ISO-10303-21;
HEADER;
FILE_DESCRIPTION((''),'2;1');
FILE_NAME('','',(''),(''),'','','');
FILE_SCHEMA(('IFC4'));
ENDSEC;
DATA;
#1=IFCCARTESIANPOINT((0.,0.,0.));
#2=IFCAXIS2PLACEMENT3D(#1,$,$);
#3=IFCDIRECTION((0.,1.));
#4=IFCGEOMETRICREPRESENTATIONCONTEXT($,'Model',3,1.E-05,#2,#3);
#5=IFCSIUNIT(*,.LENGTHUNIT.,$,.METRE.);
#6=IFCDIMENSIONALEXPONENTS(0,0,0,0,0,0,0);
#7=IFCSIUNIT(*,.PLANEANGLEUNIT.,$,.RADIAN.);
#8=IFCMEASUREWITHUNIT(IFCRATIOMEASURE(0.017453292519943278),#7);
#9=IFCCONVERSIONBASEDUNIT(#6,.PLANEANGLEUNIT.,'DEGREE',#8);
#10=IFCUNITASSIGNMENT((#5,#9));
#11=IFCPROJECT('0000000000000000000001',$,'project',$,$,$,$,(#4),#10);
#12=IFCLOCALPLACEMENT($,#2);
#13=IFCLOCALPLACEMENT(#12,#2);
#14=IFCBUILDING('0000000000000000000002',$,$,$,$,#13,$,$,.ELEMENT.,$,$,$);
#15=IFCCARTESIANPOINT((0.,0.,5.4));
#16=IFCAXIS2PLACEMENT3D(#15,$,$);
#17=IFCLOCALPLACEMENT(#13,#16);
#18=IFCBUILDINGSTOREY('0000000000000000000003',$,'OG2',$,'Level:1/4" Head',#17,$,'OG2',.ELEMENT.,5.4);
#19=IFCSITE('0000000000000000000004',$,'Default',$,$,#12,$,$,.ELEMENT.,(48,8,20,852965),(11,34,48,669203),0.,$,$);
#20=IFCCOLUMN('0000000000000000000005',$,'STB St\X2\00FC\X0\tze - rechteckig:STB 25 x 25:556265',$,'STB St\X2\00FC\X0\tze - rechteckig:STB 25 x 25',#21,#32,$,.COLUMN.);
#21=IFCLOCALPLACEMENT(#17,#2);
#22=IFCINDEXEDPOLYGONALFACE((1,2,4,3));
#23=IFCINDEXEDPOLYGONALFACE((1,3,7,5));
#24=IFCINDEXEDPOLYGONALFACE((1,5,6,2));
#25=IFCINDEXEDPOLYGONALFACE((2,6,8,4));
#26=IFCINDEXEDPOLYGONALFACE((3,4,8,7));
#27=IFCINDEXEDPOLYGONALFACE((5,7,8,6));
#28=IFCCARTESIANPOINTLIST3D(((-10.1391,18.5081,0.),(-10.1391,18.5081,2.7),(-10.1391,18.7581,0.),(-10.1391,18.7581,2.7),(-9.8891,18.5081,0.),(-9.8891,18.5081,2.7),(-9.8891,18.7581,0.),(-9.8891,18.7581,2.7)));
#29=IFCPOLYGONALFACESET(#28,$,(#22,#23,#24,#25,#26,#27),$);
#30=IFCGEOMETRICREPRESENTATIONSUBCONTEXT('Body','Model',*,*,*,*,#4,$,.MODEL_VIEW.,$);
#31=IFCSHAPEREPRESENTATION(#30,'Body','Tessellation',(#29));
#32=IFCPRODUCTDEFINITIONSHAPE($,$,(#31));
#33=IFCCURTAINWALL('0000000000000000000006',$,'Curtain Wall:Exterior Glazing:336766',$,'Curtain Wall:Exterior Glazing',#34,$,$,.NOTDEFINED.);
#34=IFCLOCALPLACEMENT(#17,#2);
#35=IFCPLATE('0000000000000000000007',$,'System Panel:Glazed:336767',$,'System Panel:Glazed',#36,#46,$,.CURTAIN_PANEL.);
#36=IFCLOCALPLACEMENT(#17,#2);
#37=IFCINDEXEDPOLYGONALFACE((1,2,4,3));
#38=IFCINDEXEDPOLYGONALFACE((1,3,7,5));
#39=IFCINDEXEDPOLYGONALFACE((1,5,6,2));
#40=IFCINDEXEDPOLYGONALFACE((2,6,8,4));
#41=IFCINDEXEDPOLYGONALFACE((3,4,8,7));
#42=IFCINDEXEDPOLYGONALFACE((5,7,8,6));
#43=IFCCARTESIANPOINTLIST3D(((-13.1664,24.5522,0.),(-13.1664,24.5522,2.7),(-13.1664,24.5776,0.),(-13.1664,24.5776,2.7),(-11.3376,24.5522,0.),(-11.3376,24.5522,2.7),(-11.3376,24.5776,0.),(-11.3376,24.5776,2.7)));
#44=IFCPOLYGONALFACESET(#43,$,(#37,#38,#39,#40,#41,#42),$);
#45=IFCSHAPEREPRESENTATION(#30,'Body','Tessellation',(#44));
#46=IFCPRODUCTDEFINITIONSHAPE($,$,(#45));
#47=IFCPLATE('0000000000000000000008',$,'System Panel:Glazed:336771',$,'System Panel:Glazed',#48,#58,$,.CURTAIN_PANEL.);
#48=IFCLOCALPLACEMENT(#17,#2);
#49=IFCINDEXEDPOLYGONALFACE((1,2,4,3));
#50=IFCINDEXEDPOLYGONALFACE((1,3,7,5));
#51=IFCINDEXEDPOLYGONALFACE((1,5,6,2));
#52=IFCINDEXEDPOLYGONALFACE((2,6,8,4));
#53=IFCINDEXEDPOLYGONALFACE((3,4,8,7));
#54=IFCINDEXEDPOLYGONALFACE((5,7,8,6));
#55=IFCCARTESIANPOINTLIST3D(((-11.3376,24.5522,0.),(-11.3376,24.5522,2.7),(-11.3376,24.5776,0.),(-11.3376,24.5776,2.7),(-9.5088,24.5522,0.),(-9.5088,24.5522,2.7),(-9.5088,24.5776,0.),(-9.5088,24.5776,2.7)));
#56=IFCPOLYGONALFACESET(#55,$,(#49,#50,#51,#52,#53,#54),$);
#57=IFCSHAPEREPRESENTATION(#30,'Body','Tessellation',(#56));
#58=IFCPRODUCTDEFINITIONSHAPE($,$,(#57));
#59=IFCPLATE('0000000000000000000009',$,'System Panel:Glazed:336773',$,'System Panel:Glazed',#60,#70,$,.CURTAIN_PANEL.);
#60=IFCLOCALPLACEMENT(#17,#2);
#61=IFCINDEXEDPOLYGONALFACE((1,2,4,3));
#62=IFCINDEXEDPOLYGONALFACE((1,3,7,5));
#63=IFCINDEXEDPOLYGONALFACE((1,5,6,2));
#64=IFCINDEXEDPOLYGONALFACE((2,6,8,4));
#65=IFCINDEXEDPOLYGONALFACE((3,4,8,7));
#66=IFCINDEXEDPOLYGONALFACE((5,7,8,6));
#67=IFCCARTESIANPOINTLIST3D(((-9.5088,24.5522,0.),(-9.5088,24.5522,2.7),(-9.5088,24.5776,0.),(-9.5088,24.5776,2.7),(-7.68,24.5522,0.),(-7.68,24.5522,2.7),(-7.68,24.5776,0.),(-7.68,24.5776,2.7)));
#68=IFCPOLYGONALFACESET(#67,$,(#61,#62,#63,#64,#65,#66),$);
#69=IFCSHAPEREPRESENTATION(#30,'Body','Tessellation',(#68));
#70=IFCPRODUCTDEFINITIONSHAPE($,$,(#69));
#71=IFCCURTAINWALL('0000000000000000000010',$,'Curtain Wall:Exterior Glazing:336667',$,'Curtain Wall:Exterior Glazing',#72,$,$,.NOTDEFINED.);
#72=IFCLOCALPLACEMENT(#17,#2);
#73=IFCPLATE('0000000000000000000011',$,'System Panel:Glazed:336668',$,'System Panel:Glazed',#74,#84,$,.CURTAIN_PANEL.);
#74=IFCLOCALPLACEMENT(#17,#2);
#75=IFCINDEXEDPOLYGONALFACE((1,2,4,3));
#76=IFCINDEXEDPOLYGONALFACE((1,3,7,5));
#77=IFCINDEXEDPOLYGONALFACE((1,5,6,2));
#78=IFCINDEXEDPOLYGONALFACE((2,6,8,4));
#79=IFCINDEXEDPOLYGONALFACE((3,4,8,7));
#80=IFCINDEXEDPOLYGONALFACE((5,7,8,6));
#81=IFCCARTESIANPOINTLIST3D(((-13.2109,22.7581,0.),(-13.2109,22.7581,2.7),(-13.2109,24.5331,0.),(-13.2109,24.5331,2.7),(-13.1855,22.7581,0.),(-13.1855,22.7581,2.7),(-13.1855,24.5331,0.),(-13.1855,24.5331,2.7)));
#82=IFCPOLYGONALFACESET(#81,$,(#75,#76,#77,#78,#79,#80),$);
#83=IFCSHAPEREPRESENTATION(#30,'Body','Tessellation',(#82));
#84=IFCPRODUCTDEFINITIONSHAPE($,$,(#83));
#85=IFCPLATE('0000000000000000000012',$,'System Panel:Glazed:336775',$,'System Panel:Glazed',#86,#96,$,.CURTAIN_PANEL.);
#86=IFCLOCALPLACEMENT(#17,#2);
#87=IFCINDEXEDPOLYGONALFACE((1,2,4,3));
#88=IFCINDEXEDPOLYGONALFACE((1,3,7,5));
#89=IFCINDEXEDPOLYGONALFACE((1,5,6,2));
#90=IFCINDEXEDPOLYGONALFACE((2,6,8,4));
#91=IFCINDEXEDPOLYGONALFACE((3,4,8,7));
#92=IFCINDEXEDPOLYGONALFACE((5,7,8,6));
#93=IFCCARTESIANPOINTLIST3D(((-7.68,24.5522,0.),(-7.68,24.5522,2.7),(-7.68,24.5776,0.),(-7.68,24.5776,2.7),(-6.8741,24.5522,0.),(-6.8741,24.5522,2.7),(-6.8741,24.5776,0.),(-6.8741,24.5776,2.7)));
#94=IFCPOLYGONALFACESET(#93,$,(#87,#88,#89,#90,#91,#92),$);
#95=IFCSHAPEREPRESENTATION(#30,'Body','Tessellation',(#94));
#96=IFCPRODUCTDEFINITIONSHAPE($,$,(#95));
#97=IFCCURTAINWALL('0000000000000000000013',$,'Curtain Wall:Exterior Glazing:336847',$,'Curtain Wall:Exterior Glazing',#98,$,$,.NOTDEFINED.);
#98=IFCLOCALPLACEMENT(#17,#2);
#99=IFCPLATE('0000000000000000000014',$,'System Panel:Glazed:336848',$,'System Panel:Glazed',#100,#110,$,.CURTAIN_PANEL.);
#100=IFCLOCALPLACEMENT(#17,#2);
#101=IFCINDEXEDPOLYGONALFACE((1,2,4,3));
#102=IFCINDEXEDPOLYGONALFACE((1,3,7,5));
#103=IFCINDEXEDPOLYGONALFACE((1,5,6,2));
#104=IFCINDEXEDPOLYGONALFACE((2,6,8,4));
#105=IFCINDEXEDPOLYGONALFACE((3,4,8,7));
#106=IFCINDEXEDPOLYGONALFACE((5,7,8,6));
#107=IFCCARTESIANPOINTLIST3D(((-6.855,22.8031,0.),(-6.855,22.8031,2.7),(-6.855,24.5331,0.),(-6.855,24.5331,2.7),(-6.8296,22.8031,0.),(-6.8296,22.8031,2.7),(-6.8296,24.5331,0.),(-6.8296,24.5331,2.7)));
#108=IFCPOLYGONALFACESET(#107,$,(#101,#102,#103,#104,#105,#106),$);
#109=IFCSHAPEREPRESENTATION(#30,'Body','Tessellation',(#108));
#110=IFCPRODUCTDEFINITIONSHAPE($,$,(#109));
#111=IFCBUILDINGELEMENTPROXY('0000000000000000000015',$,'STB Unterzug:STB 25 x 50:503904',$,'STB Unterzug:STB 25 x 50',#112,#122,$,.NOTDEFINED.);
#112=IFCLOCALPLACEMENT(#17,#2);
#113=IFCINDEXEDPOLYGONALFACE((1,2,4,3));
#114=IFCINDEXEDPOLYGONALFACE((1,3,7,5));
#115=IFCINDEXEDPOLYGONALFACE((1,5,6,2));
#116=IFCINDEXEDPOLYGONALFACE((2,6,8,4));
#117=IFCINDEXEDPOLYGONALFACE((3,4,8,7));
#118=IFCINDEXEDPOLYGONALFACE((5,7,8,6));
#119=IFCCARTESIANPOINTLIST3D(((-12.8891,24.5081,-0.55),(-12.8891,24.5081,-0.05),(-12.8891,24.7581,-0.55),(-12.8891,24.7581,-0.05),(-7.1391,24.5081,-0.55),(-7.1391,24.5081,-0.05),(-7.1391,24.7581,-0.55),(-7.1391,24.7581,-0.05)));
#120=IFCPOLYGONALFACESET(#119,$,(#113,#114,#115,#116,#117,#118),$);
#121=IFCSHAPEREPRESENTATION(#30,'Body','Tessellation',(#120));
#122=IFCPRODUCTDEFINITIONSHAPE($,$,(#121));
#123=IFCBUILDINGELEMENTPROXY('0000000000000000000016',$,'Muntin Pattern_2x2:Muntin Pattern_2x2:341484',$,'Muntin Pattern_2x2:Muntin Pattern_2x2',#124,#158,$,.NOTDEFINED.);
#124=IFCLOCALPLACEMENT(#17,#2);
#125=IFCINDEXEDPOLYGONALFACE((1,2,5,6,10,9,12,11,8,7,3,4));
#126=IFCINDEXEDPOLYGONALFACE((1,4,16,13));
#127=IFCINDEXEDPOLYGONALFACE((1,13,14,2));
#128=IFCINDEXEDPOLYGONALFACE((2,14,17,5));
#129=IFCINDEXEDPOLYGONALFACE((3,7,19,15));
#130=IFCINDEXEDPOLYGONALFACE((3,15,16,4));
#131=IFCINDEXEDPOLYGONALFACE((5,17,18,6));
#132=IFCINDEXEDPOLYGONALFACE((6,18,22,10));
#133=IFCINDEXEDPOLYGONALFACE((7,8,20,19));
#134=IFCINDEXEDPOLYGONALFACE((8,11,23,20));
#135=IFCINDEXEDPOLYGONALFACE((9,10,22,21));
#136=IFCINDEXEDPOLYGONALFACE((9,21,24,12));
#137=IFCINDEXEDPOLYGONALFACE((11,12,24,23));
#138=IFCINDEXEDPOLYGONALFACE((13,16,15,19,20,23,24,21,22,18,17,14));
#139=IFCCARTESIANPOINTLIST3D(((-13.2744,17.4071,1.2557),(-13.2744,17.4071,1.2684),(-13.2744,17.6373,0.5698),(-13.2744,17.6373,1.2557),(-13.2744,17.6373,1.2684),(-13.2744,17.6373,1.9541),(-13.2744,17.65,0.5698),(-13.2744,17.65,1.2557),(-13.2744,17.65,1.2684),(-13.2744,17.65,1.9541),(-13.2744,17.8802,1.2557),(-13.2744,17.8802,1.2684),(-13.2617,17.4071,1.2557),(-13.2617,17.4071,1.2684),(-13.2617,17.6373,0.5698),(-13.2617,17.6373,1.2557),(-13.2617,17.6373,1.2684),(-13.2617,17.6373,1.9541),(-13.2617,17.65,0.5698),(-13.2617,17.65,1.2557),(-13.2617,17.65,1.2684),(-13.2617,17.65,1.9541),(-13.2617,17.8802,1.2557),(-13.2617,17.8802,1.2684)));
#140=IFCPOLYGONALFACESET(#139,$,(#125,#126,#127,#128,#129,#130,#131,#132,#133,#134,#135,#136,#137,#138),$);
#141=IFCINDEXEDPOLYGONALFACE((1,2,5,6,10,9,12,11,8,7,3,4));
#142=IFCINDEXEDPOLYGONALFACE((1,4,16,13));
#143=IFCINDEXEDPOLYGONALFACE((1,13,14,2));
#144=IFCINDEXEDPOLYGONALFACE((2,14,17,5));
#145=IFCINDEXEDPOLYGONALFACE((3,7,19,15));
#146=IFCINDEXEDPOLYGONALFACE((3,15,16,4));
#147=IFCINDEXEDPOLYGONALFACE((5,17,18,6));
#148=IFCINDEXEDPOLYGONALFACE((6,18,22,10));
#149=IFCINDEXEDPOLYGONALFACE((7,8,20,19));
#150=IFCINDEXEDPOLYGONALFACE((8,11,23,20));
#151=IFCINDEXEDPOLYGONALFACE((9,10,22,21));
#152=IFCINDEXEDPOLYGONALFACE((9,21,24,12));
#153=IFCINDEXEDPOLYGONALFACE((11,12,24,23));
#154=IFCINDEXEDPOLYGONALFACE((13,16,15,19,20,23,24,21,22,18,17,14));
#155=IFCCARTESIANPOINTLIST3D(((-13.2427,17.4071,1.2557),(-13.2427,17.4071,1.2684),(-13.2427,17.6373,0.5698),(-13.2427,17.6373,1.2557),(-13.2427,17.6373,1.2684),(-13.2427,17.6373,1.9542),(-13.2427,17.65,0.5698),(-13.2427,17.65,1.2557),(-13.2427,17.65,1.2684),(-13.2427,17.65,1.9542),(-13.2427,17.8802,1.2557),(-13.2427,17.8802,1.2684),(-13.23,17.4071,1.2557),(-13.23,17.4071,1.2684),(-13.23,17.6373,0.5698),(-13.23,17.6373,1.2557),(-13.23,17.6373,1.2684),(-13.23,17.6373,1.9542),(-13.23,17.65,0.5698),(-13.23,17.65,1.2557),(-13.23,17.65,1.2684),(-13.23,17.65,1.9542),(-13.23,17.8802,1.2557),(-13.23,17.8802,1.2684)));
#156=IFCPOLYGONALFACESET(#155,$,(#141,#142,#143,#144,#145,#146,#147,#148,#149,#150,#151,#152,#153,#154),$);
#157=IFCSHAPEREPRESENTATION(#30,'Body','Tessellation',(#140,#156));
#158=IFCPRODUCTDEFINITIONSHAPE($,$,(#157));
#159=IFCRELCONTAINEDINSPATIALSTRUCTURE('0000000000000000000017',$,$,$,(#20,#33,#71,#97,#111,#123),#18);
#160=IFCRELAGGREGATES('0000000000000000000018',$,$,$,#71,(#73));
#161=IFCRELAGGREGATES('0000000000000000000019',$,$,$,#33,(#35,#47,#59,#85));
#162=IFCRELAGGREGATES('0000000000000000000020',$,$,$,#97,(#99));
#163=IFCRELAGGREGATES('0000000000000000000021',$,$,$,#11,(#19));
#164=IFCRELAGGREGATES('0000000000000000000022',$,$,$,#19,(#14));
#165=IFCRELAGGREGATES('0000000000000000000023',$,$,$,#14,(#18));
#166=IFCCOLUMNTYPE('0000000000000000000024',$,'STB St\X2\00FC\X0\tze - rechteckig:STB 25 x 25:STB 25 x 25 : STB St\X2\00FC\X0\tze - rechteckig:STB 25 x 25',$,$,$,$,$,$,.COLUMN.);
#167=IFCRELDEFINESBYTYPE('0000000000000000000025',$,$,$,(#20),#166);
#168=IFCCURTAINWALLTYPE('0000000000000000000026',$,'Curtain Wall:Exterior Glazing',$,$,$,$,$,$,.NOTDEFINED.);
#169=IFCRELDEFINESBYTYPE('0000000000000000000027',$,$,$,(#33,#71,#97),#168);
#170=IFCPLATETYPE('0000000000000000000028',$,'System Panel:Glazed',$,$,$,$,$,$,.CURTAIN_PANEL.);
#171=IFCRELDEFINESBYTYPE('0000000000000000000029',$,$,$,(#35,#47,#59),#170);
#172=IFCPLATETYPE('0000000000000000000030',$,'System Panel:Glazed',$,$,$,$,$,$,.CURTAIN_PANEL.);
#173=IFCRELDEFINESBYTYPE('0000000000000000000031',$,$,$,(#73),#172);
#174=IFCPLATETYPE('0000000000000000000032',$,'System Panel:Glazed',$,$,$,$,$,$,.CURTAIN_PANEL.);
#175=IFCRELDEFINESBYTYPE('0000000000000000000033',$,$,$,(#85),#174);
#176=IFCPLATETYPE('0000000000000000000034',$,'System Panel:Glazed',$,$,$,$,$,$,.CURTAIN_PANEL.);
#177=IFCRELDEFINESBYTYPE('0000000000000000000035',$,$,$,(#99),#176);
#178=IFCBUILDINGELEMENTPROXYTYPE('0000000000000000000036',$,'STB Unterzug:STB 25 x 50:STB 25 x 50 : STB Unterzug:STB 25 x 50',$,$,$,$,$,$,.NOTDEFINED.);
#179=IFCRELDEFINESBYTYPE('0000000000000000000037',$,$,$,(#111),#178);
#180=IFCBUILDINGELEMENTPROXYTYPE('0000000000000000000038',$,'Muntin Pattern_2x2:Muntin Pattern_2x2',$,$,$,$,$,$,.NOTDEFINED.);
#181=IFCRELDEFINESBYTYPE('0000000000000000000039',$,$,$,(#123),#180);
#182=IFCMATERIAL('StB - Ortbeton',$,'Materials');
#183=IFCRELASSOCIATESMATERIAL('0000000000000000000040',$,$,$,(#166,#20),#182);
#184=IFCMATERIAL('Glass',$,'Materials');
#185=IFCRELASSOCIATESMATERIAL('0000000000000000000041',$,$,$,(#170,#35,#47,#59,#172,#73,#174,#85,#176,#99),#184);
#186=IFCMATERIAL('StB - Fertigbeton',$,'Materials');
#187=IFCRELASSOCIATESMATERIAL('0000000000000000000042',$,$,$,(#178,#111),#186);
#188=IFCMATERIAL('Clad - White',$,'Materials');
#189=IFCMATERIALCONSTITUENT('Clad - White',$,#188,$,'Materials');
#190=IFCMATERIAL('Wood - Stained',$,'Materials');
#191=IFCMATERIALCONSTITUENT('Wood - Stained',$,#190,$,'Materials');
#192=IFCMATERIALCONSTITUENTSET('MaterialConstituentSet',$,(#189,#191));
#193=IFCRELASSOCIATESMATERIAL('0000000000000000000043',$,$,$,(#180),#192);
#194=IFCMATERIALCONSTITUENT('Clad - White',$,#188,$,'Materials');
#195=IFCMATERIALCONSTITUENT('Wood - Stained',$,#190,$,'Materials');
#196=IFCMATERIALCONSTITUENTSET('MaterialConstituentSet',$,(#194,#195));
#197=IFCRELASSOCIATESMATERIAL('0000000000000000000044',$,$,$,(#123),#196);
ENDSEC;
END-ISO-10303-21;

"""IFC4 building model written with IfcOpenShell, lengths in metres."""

from ifc_helpers import new_model, entity, si_unit, converted_unit, direction, frame, origin, place, context, subcontext, project, spatial, indexed_curve, outline, extrude, source, transform, mapped, material, constituent, constituent_set, type_object, type_shapes, element, aggregate, save


model = new_model("IFC4")

# Units and contexts
model_context = context("Model", 3, precision=1e-05, world=origin(), true_north=direction((0.0, 1.0)))
body_context = subcontext(model_context, "Body", "Model", "MODEL_VIEW")
ifc_project = project(units=[si_unit("LENGTHUNIT", "METRE"), converted_unit("PLANEANGLEUNIT", "DEGREE", entity("IfcRatioMeasure", 0.017453292519943278), si_unit("PLANEANGLEUNIT", "RADIAN"), dimensions=[0, 0, 0, 0, 0, 0, 0])], contexts=[model_context])

# Site, building, storey
site_placement = place(None, origin())
site = spatial("IfcSite", under=ifc_project, at=site_placement, Name="Default", CompositionType="ELEMENT", RefLatitude=(48, 8, 20, 852965), RefLongitude=(11, 34, 48, 669203), RefElevation=0.0)
building_placement = place(site_placement, origin())
building = spatial("IfcBuilding", under=site, at=building_placement, CompositionType="ELEMENT")
storey_placement = place(building_placement, frame((0.0, 0.0, 5.4)))
storey = spatial("IfcBuildingStorey", under=building, at=storey_placement, Name="OG2", ObjectType="Level:1/4\" Head", LongName="OG2", CompositionType="ELEMENT", Elevation=5.4)

# Column
ifc_material_1 = material(Name="StB - Ortbeton", Category="Materials")
column_type = type_object("IfcColumnType", Name="STB Stütze - rechteckig:STB 25 x 25:STB 25 x 25 : STB Stütze - rechteckig:STB 25 x 25", PredefinedType="COLUMN", material=ifc_material_1)
shared_shape_1 = source(origin(), body_context, "Body", "SweptSolid", [
    extrude(outline(indexed_curve([(-0.125, -0.125), (0.125, -0.125), (0.125, 0.125), (-0.125, 0.125), (-0.125, -0.125)], self_intersect=False)), frame((0.0, 0.0, 5.4), z_axis=(0.0, 0.0, 1.0), x_axis=(0.0, -1.0, 0.0)), (0.0, 0.0, 1.0), 2.7),
])
type_shapes(column_type, [shared_shape_1])
column_placement = place(storey_placement, frame((-10.0141, 18.6331, -5.4)))
element("IfcColumn", 1, at=column_placement, inside=storey, type_object=column_type, material=ifc_material_1, Name="STB Stütze - rechteckig:STB 25 x 25:556265", ObjectType="STB Stütze - rechteckig:STB 25 x 25", PredefinedType="COLUMN", context=body_context, shape_type="MappedRepresentation", body=[
    mapped(shared_shape_1, transform((0.0, 0.0, 0.0), scale=1.0)),
])

# Curtain wall, plates
curtain_wall_type = type_object("IfcCurtainWallType", Name="Curtain Wall:Exterior Glazing", PredefinedType="NOTDEFINED")
curtain_wall_1_placement = place(storey_placement, frame((0.0, 0.0, -5.4)))
curtain_wall_1 = element("IfcCurtainWall", 2, at=curtain_wall_1_placement, inside=storey, type_object=curtain_wall_type, Name="Curtain Wall:Exterior Glazing:336766", ObjectType="Curtain Wall:Exterior Glazing", PredefinedType="NOTDEFINED")
ifc_material_2 = material(Name="Glass", Category="Materials")
plate_type_1 = type_object("IfcPlateType", Name="System Panel:Glazed", PredefinedType="CURTAIN_PANEL", material=ifc_material_2)
shared_shape_2 = source(origin(), body_context, "Body", "SweptSolid", [
    extrude(outline(indexed_curve([(-0.0127, -0.9144), (0.0127, -0.9144), (0.0127, 0.9144), (-0.0127, 0.9144), (-0.0127, -0.9144)], self_intersect=False)), frame((0.0, 0.0317, 0.0), z_axis=(0.0, 0.0, 1.0), x_axis=(0.0, 1.0, 0.0)), (0.0, 0.0, 1.0), 2.7),
])
type_shapes(plate_type_1, [shared_shape_2])
plate_1_placement = place(curtain_wall_1_placement, frame((-12.252, 24.5331, 5.4)))
plate_1 = element("IfcPlate", 3, at=plate_1_placement, type_object=plate_type_1, material=ifc_material_2, Name="System Panel:Glazed:336767", ObjectType="System Panel:Glazed", PredefinedType="CURTAIN_PANEL", context=body_context, shape_type="MappedRepresentation", body=[
    mapped(shared_shape_2, transform((0.0, 0.0, 0.0), scale=1.0)),
])
plate_2_placement = place(curtain_wall_1_placement, frame((-10.4232, 24.5331, 5.4)))
plate_2 = element("IfcPlate", 4, at=plate_2_placement, type_object=plate_type_1, material=ifc_material_2, Name="System Panel:Glazed:336771", ObjectType="System Panel:Glazed", PredefinedType="CURTAIN_PANEL", context=body_context, shape_type="MappedRepresentation", body=[
    mapped(shared_shape_2, transform((0.0, 0.0, 0.0), scale=1.0)),
])
plate_3_placement = place(curtain_wall_1_placement, frame((-8.5944, 24.5331, 5.4)))
plate_3 = element("IfcPlate", 5, at=plate_3_placement, type_object=plate_type_1, material=ifc_material_2, Name="System Panel:Glazed:336773", ObjectType="System Panel:Glazed", PredefinedType="CURTAIN_PANEL", context=body_context, shape_type="MappedRepresentation", body=[
    mapped(shared_shape_2, transform((0.0, 0.0, 0.0), scale=1.0)),
])

# Curtain wall, plate
curtain_wall_2_placement = place(storey_placement, frame((0.0, 0.0, -5.4)))
curtain_wall_2 = element("IfcCurtainWall", 6, at=curtain_wall_2_placement, inside=storey, type_object=curtain_wall_type, Name="Curtain Wall:Exterior Glazing:336667", ObjectType="Curtain Wall:Exterior Glazing", PredefinedType="NOTDEFINED")
plate_type_2 = type_object("IfcPlateType", Name="System Panel:Glazed", PredefinedType="CURTAIN_PANEL", material=ifc_material_2)
shared_shape_3 = source(origin(), body_context, "Body", "SweptSolid", [
    extrude(outline(indexed_curve([(-0.0127, -0.8875), (0.0127, -0.8875), (0.0127, 0.8875), (-0.0127, 0.8875), (-0.0127, -0.8875)], self_intersect=False)), frame((0.0, 0.0317, 0.0), z_axis=(0.0, 0.0, 1.0), x_axis=(0.0, 1.0, 0.0)), (0.0, 0.0, 1.0), 2.7),
])
type_shapes(plate_type_2, [shared_shape_3])
plate_4_placement = place(curtain_wall_2_placement, frame((-13.1664, 23.6456, 5.4), z_axis=(0.0, 0.0, 1.0), x_axis=(0.0, 1.0, 0.0)))
plate_4 = element("IfcPlate", 7, at=plate_4_placement, type_object=plate_type_2, material=ifc_material_2, Name="System Panel:Glazed:336668", ObjectType="System Panel:Glazed", PredefinedType="CURTAIN_PANEL", context=body_context, shape_type="MappedRepresentation", body=[
    mapped(shared_shape_3, transform((0.0, 0.0, 0.0), scale=1.0)),
])
aggregate(curtain_wall_2, [plate_4])

# Plate
plate_type_3 = type_object("IfcPlateType", Name="System Panel:Glazed", PredefinedType="CURTAIN_PANEL", material=ifc_material_2)
shared_shape_4 = source(origin(), body_context, "Body", "SweptSolid", [
    extrude(outline(indexed_curve([(-0.0127, -0.403), (0.0127, -0.403), (0.0127, 0.403), (-0.0127, 0.403), (-0.0127, -0.403)], self_intersect=False)), frame((0.0, 0.0318, 0.0), z_axis=(0.0, 0.0, 1.0), x_axis=(0.0, 1.0, 0.0)), (0.0, 0.0, 1.0), 2.7),
])
type_shapes(plate_type_3, [shared_shape_4])
plate_5_placement = place(curtain_wall_1_placement, frame((-7.277, 24.5331, 5.4)))
plate_5 = element("IfcPlate", 8, at=plate_5_placement, type_object=plate_type_3, material=ifc_material_2, Name="System Panel:Glazed:336775", ObjectType="System Panel:Glazed", PredefinedType="CURTAIN_PANEL", context=body_context, shape_type="MappedRepresentation", body=[
    mapped(shared_shape_4, transform((0.0, 0.0, 0.0), scale=1.0)),
])
aggregate(curtain_wall_1, [plate_1, plate_2, plate_3, plate_5])

# Curtain wall, plate
curtain_wall_3_placement = place(storey_placement, frame((0.0, 0.0, -5.4)))
curtain_wall_3 = element("IfcCurtainWall", 9, at=curtain_wall_3_placement, inside=storey, type_object=curtain_wall_type, Name="Curtain Wall:Exterior Glazing:336847", ObjectType="Curtain Wall:Exterior Glazing", PredefinedType="NOTDEFINED")
plate_type_4 = type_object("IfcPlateType", Name="System Panel:Glazed", PredefinedType="CURTAIN_PANEL", material=ifc_material_2)
shared_shape_5 = source(origin(), body_context, "Body", "SweptSolid", [
    extrude(outline(indexed_curve([(-0.0127, -0.865), (0.0127, -0.865), (0.0127, 0.865), (-0.0127, 0.865), (-0.0127, -0.865)], self_intersect=False)), frame((0.0, 0.0318, 0.0), z_axis=(0.0, 0.0, 1.0), x_axis=(0.0, 1.0, 0.0)), (0.0, 0.0, 1.0), 2.7),
])
type_shapes(plate_type_4, [shared_shape_5])
plate_6_placement = place(curtain_wall_3_placement, frame((-6.8741, 23.6681, 5.4), z_axis=(0.0, 0.0, 1.0), x_axis=(0.0, -1.0, 0.0)))
plate_6 = element("IfcPlate", 10, at=plate_6_placement, type_object=plate_type_4, material=ifc_material_2, Name="System Panel:Glazed:336848", ObjectType="System Panel:Glazed", PredefinedType="CURTAIN_PANEL", context=body_context, shape_type="MappedRepresentation", body=[
    mapped(shared_shape_5, transform((0.0, 0.0, 0.0), scale=1.0)),
])
aggregate(curtain_wall_3, [plate_6])

# Building element proxies
ifc_material_3 = material(Name="StB - Fertigbeton", Category="Materials")
building_element_proxy_type_1 = type_object("IfcBuildingElementProxyType", Name="STB Unterzug:STB 25 x 50:STB 25 x 50 : STB Unterzug:STB 25 x 50", PredefinedType="NOTDEFINED", material=ifc_material_3)
shared_shape_6 = source(origin(), body_context, "Body", "SweptSolid", [
    extrude(outline(indexed_curve([(-2.875, -0.125), (2.875, -0.125), (2.875, 0.125), (-2.875, 0.125), (-2.875, -0.125)], self_intersect=False)), frame((0.0, 0.0, -0.25), z_axis=(0.0, 0.0, 1.0), x_axis=(-1.0, 0.0, 0.0)), (0.0, 0.0, 1.0), 0.5),
])
type_shapes(building_element_proxy_type_1, [shared_shape_6])
proxy_1_placement = place(storey_placement, frame((-10.0141, 24.6331, -0.3)))
element("IfcBuildingElementProxy", 11, at=proxy_1_placement, inside=storey, type_object=building_element_proxy_type_1, material=ifc_material_3, Name="STB Unterzug:STB 25 x 50:503904", ObjectType="STB Unterzug:STB 25 x 50", PredefinedType="NOTDEFINED", context=body_context, shape_type="MappedRepresentation", body=[
    mapped(shared_shape_6, transform((0.0, 0.0, 0.0), scale=1.0)),
])
ifc_material_4 = material(Name="Clad - White", Category="Materials")
ifc_constituent_1 = constituent(ifc_material_4, Name="Clad - White", Category="Materials")
ifc_material_5 = material(Name="Wood - Stained", Category="Materials")
ifc_constituent_2 = constituent(ifc_material_5, Name="Wood - Stained", Category="Materials")
ifc_constituent_set_1 = constituent_set(constituents=[ifc_constituent_1, ifc_constituent_2], Name="MaterialConstituentSet")
ifc_constituent_3 = constituent(ifc_material_4, Name="Clad - White", Category="Materials")
ifc_constituent_4 = constituent(ifc_material_5, Name="Wood - Stained", Category="Materials")
ifc_constituent_set_2 = constituent_set(constituents=[ifc_constituent_3, ifc_constituent_4], Name="MaterialConstituentSet")
building_element_proxy_type_2 = type_object("IfcBuildingElementProxyType", Name="Muntin Pattern_2x2:Muntin Pattern_2x2", PredefinedType="NOTDEFINED", material=ifc_constituent_set_2)
shared_shape_7 = source(origin(), body_context, "Body", "SweptSolid", [
    extrude(outline(indexed_curve([(0.0064, -0.0064), (0.6921, -0.0064), (0.6921, 0.0063), (0.0064, 0.0063), (0.0064, 0.2365), (-0.0063, 0.2365), (-0.0063, 0.0063), (-0.6922, 0.0063), (-0.6922, -0.0064), (-0.0063, -0.0064), (-0.0063, -0.2365), (0.0064, -0.2365), (0.0064, -0.0064)], self_intersect=False)), frame((0.0, -0.0222, 0.6921), z_axis=(0.0, 1.0, 0.0), x_axis=(0.0, 0.0, 1.0)), (0.0, 0.0, 1.0), 0.0127),
    extrude(outline(indexed_curve([(0.0064, -0.0064), (0.6922, -0.0064), (0.6922, 0.0063), (0.0064, 0.0063), (0.0064, 0.2365), (-0.0063, 0.2365), (-0.0063, 0.0063), (-0.6922, 0.0063), (-0.6922, -0.0064), (-0.0063, -0.0064), (-0.0063, -0.2365), (0.0064, -0.2365), (0.0064, -0.0064)], self_intersect=False)), frame((0.0, 0.0095, 0.6922), z_axis=(0.0, 1.0, 0.0), x_axis=(0.0, 0.0, 1.0)), (0.0, 0.0, 1.0), 0.0127),
])
type_shapes(building_element_proxy_type_2, [shared_shape_7])
proxy_2_placement = place(storey_placement, frame((-13.2522, 17.6437, 0.5699), z_axis=(0.0, 0.0, 1.0), x_axis=(0.0, -1.0, 0.0)))
element("IfcBuildingElementProxy", 12, at=proxy_2_placement, inside=storey, type_object=building_element_proxy_type_2, material=ifc_constituent_set_1, Name="Muntin Pattern_2x2:Muntin Pattern_2x2:341484", ObjectType="Muntin Pattern_2x2:Muntin Pattern_2x2", PredefinedType="NOTDEFINED", context=body_context, shape_type="MappedRepresentation", body=[
    mapped(shared_shape_7, transform((0.0, 0.0, 0.0), scale=1.0)),
])

save(model, "model.ifc")
